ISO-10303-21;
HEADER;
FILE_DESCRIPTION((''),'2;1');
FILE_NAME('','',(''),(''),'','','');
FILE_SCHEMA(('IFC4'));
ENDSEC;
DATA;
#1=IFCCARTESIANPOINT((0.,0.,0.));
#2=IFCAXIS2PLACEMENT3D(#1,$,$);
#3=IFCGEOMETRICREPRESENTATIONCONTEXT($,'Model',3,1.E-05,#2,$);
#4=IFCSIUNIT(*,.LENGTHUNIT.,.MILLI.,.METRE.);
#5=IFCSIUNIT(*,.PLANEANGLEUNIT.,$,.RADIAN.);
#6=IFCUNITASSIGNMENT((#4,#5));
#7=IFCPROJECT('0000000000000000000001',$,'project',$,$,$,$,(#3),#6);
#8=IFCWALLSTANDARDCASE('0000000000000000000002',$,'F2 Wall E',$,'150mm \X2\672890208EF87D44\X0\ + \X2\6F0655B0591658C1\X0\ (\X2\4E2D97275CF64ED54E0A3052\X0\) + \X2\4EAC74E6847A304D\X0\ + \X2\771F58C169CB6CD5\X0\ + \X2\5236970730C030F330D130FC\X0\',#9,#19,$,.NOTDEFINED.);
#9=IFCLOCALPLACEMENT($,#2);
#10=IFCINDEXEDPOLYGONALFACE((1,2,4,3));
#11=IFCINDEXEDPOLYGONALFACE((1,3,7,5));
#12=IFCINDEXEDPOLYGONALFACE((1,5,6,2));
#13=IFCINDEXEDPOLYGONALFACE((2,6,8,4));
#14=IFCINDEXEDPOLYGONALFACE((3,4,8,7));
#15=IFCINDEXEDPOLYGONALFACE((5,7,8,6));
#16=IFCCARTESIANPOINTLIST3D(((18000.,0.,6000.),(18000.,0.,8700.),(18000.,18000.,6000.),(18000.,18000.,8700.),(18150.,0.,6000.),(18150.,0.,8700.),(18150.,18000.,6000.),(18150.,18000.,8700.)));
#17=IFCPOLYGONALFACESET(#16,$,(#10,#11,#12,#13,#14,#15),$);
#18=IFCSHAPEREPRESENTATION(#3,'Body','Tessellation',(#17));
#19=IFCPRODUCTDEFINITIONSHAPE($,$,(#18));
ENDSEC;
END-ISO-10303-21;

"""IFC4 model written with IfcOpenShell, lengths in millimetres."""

from ifc_helpers import new_model, si_unit, frame, frame_2d, origin, place, context, project, rectangle, extrude, element, save


model = new_model("IFC4")

# Units and contexts
model_context = context("Model", 3, precision=1e-05, world=origin())
ifc_project = project(units=[si_unit("LENGTHUNIT", "METRE", prefix="MILLI"), si_unit("PLANEANGLEUNIT", "RADIAN")], contexts=[model_context])

# Shared definitions
placement_1 = place(None, origin())
placement_2 = place(placement_1, origin())
placement_3 = place(placement_2, origin())

# Wall
wall_1_placement = place(placement_3, frame((9000.0, 0.0, 3000.0)))
element("IfcWallStandardCase", 1, at=wall_1_placement, Name="F2 Wall E", ObjectType="150mm 木造軸組 + 漆喰外壁 (中霧島仕上げ) + 京瓦葺き + 真壁構法 + 制震ダンパー", PredefinedType="NOTDEFINED", context=model_context, shape_type="SweptSolid", body=[
    extrude(rectangle(XDim=150.0, YDim=18000.0, at=frame_2d((75.0, 9000.0))), frame((9000.0, 0.0, 3000.0)), (0.0, 0.0, 1.0), 2700.0),
])

save(model, "model.ifc")
